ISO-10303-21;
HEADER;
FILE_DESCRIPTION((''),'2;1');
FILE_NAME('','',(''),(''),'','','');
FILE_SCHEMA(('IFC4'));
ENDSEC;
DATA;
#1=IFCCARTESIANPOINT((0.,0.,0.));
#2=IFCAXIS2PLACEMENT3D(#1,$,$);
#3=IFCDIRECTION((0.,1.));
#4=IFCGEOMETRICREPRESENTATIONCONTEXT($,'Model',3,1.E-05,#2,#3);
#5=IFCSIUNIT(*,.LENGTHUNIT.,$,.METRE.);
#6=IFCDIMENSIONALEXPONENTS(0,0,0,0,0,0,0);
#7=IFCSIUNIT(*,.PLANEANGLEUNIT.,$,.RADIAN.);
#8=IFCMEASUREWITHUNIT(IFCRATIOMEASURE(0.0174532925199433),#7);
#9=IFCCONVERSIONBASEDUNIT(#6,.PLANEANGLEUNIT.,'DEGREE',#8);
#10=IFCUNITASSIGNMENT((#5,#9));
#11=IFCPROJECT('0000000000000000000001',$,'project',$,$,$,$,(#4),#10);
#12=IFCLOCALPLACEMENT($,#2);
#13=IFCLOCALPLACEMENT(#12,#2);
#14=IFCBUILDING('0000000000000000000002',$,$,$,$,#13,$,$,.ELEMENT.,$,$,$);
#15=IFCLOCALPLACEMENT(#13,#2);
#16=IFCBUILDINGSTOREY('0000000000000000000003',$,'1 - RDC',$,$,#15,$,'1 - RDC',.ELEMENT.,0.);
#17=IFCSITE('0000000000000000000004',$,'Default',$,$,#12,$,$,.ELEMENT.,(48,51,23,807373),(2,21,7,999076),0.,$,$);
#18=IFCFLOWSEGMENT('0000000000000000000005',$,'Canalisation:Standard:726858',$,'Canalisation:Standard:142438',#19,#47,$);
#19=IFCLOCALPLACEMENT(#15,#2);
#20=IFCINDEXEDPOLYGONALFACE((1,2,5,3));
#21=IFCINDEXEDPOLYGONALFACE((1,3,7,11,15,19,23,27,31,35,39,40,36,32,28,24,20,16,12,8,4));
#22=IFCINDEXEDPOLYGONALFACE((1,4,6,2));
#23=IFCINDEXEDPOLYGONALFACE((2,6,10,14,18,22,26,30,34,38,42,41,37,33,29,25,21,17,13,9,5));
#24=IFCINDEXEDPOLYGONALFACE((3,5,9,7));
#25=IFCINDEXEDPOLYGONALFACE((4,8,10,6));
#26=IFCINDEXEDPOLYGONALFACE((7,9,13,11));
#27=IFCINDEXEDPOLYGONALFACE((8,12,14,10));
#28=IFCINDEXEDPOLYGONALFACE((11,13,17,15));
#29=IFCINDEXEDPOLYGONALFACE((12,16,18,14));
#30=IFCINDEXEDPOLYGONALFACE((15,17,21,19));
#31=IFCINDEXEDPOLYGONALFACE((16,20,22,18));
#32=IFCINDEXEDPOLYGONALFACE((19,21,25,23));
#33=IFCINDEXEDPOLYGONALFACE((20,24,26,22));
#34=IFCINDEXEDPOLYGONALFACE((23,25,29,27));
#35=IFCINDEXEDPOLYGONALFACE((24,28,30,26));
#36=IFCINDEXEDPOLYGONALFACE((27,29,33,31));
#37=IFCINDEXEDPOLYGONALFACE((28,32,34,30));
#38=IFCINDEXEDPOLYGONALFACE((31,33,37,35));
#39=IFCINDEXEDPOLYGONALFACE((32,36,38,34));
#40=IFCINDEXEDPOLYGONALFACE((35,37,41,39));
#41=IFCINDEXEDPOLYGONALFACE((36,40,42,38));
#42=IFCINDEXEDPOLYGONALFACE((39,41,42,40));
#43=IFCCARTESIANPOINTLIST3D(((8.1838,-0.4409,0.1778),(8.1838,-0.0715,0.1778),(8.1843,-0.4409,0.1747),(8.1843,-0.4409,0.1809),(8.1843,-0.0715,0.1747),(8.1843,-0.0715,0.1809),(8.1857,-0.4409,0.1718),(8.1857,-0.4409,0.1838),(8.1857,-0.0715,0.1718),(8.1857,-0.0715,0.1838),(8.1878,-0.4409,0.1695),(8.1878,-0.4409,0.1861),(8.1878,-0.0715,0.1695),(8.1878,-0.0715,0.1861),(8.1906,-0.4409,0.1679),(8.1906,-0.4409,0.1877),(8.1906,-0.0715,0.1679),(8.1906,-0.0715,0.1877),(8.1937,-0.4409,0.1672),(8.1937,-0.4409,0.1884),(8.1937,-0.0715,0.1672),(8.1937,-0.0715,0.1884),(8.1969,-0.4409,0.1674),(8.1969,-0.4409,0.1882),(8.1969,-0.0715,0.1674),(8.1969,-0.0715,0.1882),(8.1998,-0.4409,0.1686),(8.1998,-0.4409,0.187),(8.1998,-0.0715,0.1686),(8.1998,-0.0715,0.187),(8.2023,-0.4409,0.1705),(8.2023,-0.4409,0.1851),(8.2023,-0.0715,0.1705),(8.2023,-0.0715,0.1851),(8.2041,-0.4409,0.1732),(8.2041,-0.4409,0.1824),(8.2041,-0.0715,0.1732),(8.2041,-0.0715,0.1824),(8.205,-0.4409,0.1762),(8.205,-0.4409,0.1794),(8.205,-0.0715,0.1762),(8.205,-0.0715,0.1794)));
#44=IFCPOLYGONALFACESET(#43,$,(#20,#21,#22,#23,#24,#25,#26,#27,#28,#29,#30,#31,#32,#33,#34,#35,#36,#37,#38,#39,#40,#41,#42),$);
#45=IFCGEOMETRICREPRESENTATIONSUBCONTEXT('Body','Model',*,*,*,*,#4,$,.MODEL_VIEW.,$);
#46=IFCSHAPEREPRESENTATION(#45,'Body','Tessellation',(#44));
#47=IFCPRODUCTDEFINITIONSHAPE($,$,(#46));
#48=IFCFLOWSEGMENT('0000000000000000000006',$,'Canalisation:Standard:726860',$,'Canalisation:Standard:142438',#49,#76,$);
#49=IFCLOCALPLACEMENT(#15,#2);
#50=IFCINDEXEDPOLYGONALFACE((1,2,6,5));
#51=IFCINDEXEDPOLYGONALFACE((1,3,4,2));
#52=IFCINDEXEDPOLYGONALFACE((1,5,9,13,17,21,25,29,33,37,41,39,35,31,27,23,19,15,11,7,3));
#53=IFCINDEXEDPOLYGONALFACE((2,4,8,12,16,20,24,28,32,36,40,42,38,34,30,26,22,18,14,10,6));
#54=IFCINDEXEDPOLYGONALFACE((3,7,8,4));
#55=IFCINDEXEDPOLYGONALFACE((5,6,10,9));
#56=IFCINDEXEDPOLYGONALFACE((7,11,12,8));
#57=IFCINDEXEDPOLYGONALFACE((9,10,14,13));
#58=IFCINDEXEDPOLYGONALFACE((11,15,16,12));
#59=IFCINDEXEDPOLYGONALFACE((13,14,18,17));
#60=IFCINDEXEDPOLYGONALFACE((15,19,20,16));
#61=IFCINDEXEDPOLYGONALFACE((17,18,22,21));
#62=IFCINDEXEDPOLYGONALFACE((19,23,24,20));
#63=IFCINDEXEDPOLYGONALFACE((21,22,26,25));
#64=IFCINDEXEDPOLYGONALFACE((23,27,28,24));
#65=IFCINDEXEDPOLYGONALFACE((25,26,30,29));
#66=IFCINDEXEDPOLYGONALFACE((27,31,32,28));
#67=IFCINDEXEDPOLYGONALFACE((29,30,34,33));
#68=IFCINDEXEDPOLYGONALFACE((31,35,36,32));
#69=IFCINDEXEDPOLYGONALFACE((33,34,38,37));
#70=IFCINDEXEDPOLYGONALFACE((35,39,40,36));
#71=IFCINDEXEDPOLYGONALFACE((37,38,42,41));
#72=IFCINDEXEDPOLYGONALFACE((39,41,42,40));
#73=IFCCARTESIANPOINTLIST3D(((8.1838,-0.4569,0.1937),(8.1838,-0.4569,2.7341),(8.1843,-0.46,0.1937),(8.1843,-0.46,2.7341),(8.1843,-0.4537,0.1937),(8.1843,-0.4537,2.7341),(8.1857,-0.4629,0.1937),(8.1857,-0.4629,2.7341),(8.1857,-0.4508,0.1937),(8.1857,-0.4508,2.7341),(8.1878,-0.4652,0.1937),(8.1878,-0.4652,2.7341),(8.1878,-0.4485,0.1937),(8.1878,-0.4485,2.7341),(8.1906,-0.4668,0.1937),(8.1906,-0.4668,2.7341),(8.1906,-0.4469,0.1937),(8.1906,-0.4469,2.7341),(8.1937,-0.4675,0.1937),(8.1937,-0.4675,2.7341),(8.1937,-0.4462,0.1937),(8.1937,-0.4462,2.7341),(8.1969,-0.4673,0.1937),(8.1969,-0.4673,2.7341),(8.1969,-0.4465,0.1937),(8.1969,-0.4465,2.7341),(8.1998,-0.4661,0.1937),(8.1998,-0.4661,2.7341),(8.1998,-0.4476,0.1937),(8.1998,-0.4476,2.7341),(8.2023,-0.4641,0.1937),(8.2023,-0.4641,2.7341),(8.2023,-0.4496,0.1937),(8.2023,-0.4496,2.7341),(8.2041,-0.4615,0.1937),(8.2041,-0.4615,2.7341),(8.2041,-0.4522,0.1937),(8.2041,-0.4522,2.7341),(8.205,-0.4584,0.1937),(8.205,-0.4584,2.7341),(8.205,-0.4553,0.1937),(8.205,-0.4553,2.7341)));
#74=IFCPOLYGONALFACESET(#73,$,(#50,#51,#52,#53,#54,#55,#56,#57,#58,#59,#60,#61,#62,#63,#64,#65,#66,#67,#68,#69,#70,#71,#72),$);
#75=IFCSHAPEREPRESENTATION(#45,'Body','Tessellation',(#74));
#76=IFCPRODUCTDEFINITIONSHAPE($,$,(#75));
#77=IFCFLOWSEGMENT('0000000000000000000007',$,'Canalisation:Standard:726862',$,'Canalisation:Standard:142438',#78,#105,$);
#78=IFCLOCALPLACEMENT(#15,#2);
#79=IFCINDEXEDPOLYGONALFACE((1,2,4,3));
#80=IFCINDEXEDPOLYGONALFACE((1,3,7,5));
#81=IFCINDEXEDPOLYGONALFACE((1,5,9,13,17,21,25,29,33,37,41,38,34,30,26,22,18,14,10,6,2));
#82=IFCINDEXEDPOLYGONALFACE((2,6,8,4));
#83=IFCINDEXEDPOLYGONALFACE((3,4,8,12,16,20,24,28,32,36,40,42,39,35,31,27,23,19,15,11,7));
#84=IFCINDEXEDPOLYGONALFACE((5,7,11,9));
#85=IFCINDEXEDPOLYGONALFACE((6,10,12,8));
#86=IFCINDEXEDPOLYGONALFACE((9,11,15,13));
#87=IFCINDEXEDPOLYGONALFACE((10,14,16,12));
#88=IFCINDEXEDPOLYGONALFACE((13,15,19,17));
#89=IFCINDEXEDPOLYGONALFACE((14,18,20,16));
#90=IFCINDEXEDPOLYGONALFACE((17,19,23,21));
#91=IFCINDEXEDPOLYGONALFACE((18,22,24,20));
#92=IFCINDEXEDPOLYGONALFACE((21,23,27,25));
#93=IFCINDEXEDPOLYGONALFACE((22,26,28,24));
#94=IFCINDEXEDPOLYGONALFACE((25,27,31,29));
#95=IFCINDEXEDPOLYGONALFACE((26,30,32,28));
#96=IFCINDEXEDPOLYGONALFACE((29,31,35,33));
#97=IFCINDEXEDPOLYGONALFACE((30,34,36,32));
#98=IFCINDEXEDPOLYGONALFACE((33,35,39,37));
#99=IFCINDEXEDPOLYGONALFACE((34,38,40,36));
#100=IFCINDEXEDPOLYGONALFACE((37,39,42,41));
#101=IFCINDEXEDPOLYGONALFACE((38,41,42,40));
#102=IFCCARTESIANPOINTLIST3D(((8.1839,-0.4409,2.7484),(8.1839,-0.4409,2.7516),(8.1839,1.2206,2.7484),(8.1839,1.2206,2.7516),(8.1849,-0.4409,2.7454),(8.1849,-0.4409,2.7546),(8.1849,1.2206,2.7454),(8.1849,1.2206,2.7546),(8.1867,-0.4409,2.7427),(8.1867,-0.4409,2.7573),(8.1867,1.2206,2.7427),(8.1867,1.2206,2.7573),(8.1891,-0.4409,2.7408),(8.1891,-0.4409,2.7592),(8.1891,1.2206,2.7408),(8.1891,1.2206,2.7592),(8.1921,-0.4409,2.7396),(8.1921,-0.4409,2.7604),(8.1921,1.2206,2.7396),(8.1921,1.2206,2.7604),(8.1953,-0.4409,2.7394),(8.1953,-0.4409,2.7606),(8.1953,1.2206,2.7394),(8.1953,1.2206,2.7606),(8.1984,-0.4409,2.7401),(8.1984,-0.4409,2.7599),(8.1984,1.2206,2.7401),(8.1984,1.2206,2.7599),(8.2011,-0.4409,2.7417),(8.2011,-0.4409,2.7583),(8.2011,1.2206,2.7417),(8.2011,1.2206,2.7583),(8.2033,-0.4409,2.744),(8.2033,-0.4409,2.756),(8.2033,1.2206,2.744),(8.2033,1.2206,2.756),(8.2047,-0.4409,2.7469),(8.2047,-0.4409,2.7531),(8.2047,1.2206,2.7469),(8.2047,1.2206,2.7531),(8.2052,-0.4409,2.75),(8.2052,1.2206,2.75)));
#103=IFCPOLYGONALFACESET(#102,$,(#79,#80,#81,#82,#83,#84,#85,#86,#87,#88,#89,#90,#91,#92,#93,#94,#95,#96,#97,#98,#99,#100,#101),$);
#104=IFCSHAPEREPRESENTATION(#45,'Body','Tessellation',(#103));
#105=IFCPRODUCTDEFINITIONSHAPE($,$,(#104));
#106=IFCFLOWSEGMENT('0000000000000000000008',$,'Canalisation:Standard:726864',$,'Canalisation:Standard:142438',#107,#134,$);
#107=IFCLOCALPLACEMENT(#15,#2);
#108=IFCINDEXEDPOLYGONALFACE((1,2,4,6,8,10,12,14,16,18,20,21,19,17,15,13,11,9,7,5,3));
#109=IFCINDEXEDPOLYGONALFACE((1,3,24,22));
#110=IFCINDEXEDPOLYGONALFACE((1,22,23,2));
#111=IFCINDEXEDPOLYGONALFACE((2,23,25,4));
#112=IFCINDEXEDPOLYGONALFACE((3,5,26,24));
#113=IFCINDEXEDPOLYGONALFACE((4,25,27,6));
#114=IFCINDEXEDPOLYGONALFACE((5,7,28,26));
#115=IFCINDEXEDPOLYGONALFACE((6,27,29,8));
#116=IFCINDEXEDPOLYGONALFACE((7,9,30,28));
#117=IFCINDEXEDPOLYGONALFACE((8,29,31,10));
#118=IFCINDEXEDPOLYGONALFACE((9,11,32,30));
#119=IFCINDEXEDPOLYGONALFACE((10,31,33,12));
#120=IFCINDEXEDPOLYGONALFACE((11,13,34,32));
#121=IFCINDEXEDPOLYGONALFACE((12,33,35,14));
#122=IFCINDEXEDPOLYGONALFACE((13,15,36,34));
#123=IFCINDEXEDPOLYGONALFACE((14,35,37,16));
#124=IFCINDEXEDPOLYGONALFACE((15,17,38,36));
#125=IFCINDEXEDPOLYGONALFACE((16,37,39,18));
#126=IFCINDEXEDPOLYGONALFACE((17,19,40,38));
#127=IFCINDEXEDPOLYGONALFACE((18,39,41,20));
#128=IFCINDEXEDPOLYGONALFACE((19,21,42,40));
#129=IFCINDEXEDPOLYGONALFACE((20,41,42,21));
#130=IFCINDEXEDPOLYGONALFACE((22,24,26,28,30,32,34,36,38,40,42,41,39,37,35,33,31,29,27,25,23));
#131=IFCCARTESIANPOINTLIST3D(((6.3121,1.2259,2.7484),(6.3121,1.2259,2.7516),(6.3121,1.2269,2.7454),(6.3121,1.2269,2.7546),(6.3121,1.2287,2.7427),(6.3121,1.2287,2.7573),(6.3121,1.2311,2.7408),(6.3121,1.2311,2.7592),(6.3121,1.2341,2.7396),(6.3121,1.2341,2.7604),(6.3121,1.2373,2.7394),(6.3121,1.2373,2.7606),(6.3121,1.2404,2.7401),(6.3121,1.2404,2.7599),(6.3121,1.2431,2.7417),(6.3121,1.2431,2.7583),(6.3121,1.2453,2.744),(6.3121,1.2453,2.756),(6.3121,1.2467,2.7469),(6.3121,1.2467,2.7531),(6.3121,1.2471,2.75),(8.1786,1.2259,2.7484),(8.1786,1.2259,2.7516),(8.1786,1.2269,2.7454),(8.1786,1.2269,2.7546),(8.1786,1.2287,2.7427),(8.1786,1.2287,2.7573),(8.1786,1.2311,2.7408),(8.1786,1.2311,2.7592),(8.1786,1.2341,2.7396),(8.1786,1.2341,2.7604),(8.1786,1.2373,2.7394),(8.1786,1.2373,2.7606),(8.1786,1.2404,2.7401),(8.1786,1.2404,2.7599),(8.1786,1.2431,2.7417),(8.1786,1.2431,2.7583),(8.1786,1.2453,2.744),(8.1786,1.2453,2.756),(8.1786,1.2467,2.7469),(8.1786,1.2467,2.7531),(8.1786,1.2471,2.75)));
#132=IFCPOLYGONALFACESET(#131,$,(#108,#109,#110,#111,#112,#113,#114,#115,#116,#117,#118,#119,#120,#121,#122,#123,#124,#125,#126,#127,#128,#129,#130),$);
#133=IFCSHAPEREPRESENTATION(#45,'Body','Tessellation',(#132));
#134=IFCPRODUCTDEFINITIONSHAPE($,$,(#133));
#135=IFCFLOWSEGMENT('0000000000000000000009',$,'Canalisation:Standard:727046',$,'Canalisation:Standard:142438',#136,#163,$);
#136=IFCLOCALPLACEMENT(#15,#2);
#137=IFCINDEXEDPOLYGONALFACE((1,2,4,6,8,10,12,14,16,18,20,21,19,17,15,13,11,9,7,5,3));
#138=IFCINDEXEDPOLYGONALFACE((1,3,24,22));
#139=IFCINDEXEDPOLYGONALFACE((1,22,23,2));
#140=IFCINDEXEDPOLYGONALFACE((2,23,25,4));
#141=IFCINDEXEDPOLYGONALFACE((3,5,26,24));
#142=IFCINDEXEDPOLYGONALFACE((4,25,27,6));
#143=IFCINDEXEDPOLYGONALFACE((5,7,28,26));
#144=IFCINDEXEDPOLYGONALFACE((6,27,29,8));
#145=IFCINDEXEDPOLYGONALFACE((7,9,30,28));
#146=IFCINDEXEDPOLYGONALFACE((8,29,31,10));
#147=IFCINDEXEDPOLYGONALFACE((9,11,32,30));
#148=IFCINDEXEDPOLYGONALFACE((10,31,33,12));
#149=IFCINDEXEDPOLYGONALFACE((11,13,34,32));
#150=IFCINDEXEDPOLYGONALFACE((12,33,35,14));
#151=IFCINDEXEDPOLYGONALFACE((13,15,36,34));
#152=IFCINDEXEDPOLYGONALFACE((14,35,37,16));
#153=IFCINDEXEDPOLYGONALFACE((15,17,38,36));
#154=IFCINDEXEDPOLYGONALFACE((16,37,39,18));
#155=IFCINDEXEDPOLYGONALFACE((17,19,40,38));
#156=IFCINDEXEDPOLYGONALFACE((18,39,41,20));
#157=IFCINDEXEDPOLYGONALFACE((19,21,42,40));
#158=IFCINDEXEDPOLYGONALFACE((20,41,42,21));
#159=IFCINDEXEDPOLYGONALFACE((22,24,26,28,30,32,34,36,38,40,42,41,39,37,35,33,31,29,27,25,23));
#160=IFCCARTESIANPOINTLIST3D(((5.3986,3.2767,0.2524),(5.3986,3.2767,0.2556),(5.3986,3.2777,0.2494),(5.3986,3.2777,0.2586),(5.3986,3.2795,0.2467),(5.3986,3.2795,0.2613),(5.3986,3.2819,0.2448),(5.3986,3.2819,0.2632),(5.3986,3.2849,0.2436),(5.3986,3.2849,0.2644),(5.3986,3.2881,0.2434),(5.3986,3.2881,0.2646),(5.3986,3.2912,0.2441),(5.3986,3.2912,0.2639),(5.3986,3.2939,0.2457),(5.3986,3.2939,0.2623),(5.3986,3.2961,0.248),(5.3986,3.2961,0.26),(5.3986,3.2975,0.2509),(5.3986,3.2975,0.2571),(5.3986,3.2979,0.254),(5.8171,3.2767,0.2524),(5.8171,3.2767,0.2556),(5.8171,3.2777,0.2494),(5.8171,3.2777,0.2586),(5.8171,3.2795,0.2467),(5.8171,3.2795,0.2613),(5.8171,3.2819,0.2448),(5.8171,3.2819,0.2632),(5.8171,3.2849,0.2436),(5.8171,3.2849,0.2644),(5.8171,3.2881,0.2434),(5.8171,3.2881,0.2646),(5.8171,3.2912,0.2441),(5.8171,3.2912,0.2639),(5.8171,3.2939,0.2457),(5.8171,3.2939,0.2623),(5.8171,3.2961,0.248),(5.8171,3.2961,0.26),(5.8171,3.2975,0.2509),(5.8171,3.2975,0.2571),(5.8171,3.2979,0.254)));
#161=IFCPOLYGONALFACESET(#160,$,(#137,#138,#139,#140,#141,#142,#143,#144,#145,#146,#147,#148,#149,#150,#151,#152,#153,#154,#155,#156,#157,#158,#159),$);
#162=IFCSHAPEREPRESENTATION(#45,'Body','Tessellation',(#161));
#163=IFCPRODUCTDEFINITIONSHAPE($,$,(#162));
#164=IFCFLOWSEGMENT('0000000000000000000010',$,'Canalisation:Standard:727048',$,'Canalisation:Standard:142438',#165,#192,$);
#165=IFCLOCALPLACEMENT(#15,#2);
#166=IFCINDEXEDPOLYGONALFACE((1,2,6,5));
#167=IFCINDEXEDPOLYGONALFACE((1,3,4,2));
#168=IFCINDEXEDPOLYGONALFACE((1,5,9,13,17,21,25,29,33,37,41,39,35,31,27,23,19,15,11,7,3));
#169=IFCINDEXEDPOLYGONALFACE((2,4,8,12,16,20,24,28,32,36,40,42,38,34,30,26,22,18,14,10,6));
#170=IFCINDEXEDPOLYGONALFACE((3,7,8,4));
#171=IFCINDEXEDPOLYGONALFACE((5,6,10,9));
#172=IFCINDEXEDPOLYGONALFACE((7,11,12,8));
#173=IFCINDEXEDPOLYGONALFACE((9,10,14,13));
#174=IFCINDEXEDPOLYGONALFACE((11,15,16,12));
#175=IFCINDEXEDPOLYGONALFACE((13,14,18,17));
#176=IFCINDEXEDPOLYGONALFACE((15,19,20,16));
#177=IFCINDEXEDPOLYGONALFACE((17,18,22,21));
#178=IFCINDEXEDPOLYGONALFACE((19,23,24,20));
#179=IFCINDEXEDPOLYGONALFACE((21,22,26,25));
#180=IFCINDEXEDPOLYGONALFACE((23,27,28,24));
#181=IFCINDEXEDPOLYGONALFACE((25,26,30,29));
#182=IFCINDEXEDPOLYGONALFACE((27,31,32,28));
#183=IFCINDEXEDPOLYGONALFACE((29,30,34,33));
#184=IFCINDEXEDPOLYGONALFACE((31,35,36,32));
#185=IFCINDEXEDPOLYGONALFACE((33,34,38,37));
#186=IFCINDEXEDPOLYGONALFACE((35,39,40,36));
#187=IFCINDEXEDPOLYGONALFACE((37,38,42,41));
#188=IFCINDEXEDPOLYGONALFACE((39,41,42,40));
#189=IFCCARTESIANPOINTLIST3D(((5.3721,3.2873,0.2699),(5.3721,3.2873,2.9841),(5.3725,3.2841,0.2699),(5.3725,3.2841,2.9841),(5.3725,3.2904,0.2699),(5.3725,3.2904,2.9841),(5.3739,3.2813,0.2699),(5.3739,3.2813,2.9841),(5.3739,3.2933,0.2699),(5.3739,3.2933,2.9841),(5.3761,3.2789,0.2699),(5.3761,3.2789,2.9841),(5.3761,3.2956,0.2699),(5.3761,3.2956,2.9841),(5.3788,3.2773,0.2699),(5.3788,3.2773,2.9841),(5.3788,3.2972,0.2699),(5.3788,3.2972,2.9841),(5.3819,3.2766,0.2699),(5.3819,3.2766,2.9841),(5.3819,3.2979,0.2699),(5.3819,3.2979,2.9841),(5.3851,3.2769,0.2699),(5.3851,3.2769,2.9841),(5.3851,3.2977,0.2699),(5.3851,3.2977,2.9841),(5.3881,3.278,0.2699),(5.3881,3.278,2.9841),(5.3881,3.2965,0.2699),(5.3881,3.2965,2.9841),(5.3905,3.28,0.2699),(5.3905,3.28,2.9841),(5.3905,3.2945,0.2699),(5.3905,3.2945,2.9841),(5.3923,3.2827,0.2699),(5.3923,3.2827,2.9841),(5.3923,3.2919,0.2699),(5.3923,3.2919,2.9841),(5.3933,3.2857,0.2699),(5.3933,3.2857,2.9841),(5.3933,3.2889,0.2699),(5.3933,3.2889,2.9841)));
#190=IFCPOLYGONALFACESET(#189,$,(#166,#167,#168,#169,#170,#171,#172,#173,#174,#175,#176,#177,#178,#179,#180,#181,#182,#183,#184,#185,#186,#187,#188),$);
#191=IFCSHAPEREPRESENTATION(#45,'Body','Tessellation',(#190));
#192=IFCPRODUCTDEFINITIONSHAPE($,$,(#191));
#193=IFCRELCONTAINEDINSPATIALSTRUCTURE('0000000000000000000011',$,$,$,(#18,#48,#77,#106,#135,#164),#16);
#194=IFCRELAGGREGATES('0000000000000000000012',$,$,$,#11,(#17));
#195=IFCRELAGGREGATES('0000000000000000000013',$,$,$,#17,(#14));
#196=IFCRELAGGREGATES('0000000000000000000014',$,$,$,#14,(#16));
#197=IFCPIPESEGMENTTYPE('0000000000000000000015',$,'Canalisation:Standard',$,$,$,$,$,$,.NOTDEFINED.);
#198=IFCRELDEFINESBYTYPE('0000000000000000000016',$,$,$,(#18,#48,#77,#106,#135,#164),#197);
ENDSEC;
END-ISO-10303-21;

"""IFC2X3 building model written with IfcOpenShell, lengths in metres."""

from ifc_helpers import new_model, entity, si_unit, converted_unit, direction, frame, frame_2d, origin, origin_2d_with_axis, place, context, subcontext, project, spatial, circle, extrude, type_object, element, save


model = new_model("IFC2X3")

# Units and contexts
model_context = context("Model", 3, precision=1e-05, world=origin(), true_north=direction((0.0, 1.0)))
body_context = subcontext(model_context, "Body", "Model", "MODEL_VIEW")
ifc_project = project(units=[si_unit("LENGTHUNIT", "METRE"), converted_unit("PLANEANGLEUNIT", "DEGREE", entity("IfcRatioMeasure", 0.0174532925199433), si_unit("PLANEANGLEUNIT", "RADIAN"), dimensions=[0, 0, 0, 0, 0, 0, 0])], contexts=[model_context])

# Site, building, storey
site_placement = place(None, origin())
site = spatial("IfcSite", under=ifc_project, at=site_placement, Name="Default", CompositionType="ELEMENT", RefLatitude=(48, 51, 23, 807373), RefLongitude=(2, 21, 7, 999076), RefElevation=0.0)
building_placement = place(site_placement, origin())
building = spatial("IfcBuilding", under=site, at=building_placement, CompositionType="ELEMENT")
storey_placement = place(building_placement, origin())
storey = spatial("IfcBuildingStorey", under=building, at=storey_placement, Name="1 - RDC", LongName="1 - RDC", CompositionType="ELEMENT", Elevation=0.0)

# Flow segments
pipe_segment_type = type_object("IfcPipeSegmentType", Name="Canalisation:Standard", PredefinedType="NOTDEFINED")
flow_segment_1_placement = place(storey_placement, origin())
element("IfcFlowSegment", 1, at=flow_segment_1_placement, inside=storey, type_object=pipe_segment_type, Name="Canalisation:Standard:726858", ObjectType="Canalisation:Standard:142438", context=body_context, shape_type="SweptSolid", body=[
    extrude(circle(Radius=0.0107, at=frame_2d((0.0, 0.0), x_axis=(1.0, 0.0))), frame((8.1945, -0.4409, 0.1778), z_axis=(0.0, 1.0, 0.0), x_axis=(-1.0, 0.0, 0.0)), (0.0, 0.0, 1.0), 0.3694),
])
flow_segment_2_placement = place(storey_placement, origin())
element("IfcFlowSegment", 2, at=flow_segment_2_placement, inside=storey, type_object=pipe_segment_type, Name="Canalisation:Standard:726860", ObjectType="Canalisation:Standard:142438", context=body_context, shape_type="SweptSolid", body=[
    extrude(circle(Radius=0.0107, at=frame_2d((0.0, 0.0), x_axis=(1.0, 0.0))), frame((8.1945, -0.4569, 0.1937), z_axis=(0.0, 0.0, 1.0), x_axis=(-1.0, 0.0, 0.0)), (0.0, 0.0, 1.0), 2.5404),
])
flow_segment_3_placement = place(storey_placement, origin())
element("IfcFlowSegment", 3, at=flow_segment_3_placement, inside=storey, type_object=pipe_segment_type, Name="Canalisation:Standard:726862", ObjectType="Canalisation:Standard:142438", context=body_context, shape_type="SweptSolid", body=[
    extrude(circle(Radius=0.0107, at=origin_2d_with_axis()), frame((8.1945, -0.4409, 2.75), z_axis=(0.0, 1.0, 0.0), x_axis=(1.0, 0.0, 0.0)), (0.0, 0.0, 1.0), 1.6615),
])
flow_segment_4_placement = place(storey_placement, origin())
element("IfcFlowSegment", 4, at=flow_segment_4_placement, inside=storey, type_object=pipe_segment_type, Name="Canalisation:Standard:726864", ObjectType="Canalisation:Standard:142438", context=body_context, shape_type="SweptSolid", body=[
    extrude(circle(Radius=0.0107, at=origin_2d_with_axis()), frame((6.3121, 1.2365, 2.75), z_axis=(1.0, 0.0, 0.0), x_axis=(0.0, 1.0, 0.0)), (0.0, 0.0, 1.0), 1.8665),
])
flow_segment_5_placement = place(storey_placement, origin())
element("IfcFlowSegment", 5, at=flow_segment_5_placement, inside=storey, type_object=pipe_segment_type, Name="Canalisation:Standard:727046", ObjectType="Canalisation:Standard:142438", context=body_context, shape_type="SweptSolid", body=[
    extrude(circle(Radius=0.0107, at=frame_2d((0.0, 0.0), x_axis=(1.0, 0.0))), frame((5.3986, 3.2873, 0.254), z_axis=(1.0, 0.0, 0.0), x_axis=(0.0, 1.0, 0.0)), (0.0, 0.0, 1.0), 0.4185),
])
flow_segment_6_placement = place(storey_placement, origin())
element("IfcFlowSegment", 6, at=flow_segment_6_placement, inside=storey, type_object=pipe_segment_type, Name="Canalisation:Standard:727048", ObjectType="Canalisation:Standard:142438", context=body_context, shape_type="SweptSolid", body=[
    extrude(circle(Radius=0.0107, at=origin_2d_with_axis()), frame((5.3827, 3.2873, 0.2699), z_axis=(0.0, 0.0, 1.0), x_axis=(-1.0, 0.0, 0.0)), (0.0, 0.0, 1.0), 2.7142),
])

save(model, "model.ifc")
